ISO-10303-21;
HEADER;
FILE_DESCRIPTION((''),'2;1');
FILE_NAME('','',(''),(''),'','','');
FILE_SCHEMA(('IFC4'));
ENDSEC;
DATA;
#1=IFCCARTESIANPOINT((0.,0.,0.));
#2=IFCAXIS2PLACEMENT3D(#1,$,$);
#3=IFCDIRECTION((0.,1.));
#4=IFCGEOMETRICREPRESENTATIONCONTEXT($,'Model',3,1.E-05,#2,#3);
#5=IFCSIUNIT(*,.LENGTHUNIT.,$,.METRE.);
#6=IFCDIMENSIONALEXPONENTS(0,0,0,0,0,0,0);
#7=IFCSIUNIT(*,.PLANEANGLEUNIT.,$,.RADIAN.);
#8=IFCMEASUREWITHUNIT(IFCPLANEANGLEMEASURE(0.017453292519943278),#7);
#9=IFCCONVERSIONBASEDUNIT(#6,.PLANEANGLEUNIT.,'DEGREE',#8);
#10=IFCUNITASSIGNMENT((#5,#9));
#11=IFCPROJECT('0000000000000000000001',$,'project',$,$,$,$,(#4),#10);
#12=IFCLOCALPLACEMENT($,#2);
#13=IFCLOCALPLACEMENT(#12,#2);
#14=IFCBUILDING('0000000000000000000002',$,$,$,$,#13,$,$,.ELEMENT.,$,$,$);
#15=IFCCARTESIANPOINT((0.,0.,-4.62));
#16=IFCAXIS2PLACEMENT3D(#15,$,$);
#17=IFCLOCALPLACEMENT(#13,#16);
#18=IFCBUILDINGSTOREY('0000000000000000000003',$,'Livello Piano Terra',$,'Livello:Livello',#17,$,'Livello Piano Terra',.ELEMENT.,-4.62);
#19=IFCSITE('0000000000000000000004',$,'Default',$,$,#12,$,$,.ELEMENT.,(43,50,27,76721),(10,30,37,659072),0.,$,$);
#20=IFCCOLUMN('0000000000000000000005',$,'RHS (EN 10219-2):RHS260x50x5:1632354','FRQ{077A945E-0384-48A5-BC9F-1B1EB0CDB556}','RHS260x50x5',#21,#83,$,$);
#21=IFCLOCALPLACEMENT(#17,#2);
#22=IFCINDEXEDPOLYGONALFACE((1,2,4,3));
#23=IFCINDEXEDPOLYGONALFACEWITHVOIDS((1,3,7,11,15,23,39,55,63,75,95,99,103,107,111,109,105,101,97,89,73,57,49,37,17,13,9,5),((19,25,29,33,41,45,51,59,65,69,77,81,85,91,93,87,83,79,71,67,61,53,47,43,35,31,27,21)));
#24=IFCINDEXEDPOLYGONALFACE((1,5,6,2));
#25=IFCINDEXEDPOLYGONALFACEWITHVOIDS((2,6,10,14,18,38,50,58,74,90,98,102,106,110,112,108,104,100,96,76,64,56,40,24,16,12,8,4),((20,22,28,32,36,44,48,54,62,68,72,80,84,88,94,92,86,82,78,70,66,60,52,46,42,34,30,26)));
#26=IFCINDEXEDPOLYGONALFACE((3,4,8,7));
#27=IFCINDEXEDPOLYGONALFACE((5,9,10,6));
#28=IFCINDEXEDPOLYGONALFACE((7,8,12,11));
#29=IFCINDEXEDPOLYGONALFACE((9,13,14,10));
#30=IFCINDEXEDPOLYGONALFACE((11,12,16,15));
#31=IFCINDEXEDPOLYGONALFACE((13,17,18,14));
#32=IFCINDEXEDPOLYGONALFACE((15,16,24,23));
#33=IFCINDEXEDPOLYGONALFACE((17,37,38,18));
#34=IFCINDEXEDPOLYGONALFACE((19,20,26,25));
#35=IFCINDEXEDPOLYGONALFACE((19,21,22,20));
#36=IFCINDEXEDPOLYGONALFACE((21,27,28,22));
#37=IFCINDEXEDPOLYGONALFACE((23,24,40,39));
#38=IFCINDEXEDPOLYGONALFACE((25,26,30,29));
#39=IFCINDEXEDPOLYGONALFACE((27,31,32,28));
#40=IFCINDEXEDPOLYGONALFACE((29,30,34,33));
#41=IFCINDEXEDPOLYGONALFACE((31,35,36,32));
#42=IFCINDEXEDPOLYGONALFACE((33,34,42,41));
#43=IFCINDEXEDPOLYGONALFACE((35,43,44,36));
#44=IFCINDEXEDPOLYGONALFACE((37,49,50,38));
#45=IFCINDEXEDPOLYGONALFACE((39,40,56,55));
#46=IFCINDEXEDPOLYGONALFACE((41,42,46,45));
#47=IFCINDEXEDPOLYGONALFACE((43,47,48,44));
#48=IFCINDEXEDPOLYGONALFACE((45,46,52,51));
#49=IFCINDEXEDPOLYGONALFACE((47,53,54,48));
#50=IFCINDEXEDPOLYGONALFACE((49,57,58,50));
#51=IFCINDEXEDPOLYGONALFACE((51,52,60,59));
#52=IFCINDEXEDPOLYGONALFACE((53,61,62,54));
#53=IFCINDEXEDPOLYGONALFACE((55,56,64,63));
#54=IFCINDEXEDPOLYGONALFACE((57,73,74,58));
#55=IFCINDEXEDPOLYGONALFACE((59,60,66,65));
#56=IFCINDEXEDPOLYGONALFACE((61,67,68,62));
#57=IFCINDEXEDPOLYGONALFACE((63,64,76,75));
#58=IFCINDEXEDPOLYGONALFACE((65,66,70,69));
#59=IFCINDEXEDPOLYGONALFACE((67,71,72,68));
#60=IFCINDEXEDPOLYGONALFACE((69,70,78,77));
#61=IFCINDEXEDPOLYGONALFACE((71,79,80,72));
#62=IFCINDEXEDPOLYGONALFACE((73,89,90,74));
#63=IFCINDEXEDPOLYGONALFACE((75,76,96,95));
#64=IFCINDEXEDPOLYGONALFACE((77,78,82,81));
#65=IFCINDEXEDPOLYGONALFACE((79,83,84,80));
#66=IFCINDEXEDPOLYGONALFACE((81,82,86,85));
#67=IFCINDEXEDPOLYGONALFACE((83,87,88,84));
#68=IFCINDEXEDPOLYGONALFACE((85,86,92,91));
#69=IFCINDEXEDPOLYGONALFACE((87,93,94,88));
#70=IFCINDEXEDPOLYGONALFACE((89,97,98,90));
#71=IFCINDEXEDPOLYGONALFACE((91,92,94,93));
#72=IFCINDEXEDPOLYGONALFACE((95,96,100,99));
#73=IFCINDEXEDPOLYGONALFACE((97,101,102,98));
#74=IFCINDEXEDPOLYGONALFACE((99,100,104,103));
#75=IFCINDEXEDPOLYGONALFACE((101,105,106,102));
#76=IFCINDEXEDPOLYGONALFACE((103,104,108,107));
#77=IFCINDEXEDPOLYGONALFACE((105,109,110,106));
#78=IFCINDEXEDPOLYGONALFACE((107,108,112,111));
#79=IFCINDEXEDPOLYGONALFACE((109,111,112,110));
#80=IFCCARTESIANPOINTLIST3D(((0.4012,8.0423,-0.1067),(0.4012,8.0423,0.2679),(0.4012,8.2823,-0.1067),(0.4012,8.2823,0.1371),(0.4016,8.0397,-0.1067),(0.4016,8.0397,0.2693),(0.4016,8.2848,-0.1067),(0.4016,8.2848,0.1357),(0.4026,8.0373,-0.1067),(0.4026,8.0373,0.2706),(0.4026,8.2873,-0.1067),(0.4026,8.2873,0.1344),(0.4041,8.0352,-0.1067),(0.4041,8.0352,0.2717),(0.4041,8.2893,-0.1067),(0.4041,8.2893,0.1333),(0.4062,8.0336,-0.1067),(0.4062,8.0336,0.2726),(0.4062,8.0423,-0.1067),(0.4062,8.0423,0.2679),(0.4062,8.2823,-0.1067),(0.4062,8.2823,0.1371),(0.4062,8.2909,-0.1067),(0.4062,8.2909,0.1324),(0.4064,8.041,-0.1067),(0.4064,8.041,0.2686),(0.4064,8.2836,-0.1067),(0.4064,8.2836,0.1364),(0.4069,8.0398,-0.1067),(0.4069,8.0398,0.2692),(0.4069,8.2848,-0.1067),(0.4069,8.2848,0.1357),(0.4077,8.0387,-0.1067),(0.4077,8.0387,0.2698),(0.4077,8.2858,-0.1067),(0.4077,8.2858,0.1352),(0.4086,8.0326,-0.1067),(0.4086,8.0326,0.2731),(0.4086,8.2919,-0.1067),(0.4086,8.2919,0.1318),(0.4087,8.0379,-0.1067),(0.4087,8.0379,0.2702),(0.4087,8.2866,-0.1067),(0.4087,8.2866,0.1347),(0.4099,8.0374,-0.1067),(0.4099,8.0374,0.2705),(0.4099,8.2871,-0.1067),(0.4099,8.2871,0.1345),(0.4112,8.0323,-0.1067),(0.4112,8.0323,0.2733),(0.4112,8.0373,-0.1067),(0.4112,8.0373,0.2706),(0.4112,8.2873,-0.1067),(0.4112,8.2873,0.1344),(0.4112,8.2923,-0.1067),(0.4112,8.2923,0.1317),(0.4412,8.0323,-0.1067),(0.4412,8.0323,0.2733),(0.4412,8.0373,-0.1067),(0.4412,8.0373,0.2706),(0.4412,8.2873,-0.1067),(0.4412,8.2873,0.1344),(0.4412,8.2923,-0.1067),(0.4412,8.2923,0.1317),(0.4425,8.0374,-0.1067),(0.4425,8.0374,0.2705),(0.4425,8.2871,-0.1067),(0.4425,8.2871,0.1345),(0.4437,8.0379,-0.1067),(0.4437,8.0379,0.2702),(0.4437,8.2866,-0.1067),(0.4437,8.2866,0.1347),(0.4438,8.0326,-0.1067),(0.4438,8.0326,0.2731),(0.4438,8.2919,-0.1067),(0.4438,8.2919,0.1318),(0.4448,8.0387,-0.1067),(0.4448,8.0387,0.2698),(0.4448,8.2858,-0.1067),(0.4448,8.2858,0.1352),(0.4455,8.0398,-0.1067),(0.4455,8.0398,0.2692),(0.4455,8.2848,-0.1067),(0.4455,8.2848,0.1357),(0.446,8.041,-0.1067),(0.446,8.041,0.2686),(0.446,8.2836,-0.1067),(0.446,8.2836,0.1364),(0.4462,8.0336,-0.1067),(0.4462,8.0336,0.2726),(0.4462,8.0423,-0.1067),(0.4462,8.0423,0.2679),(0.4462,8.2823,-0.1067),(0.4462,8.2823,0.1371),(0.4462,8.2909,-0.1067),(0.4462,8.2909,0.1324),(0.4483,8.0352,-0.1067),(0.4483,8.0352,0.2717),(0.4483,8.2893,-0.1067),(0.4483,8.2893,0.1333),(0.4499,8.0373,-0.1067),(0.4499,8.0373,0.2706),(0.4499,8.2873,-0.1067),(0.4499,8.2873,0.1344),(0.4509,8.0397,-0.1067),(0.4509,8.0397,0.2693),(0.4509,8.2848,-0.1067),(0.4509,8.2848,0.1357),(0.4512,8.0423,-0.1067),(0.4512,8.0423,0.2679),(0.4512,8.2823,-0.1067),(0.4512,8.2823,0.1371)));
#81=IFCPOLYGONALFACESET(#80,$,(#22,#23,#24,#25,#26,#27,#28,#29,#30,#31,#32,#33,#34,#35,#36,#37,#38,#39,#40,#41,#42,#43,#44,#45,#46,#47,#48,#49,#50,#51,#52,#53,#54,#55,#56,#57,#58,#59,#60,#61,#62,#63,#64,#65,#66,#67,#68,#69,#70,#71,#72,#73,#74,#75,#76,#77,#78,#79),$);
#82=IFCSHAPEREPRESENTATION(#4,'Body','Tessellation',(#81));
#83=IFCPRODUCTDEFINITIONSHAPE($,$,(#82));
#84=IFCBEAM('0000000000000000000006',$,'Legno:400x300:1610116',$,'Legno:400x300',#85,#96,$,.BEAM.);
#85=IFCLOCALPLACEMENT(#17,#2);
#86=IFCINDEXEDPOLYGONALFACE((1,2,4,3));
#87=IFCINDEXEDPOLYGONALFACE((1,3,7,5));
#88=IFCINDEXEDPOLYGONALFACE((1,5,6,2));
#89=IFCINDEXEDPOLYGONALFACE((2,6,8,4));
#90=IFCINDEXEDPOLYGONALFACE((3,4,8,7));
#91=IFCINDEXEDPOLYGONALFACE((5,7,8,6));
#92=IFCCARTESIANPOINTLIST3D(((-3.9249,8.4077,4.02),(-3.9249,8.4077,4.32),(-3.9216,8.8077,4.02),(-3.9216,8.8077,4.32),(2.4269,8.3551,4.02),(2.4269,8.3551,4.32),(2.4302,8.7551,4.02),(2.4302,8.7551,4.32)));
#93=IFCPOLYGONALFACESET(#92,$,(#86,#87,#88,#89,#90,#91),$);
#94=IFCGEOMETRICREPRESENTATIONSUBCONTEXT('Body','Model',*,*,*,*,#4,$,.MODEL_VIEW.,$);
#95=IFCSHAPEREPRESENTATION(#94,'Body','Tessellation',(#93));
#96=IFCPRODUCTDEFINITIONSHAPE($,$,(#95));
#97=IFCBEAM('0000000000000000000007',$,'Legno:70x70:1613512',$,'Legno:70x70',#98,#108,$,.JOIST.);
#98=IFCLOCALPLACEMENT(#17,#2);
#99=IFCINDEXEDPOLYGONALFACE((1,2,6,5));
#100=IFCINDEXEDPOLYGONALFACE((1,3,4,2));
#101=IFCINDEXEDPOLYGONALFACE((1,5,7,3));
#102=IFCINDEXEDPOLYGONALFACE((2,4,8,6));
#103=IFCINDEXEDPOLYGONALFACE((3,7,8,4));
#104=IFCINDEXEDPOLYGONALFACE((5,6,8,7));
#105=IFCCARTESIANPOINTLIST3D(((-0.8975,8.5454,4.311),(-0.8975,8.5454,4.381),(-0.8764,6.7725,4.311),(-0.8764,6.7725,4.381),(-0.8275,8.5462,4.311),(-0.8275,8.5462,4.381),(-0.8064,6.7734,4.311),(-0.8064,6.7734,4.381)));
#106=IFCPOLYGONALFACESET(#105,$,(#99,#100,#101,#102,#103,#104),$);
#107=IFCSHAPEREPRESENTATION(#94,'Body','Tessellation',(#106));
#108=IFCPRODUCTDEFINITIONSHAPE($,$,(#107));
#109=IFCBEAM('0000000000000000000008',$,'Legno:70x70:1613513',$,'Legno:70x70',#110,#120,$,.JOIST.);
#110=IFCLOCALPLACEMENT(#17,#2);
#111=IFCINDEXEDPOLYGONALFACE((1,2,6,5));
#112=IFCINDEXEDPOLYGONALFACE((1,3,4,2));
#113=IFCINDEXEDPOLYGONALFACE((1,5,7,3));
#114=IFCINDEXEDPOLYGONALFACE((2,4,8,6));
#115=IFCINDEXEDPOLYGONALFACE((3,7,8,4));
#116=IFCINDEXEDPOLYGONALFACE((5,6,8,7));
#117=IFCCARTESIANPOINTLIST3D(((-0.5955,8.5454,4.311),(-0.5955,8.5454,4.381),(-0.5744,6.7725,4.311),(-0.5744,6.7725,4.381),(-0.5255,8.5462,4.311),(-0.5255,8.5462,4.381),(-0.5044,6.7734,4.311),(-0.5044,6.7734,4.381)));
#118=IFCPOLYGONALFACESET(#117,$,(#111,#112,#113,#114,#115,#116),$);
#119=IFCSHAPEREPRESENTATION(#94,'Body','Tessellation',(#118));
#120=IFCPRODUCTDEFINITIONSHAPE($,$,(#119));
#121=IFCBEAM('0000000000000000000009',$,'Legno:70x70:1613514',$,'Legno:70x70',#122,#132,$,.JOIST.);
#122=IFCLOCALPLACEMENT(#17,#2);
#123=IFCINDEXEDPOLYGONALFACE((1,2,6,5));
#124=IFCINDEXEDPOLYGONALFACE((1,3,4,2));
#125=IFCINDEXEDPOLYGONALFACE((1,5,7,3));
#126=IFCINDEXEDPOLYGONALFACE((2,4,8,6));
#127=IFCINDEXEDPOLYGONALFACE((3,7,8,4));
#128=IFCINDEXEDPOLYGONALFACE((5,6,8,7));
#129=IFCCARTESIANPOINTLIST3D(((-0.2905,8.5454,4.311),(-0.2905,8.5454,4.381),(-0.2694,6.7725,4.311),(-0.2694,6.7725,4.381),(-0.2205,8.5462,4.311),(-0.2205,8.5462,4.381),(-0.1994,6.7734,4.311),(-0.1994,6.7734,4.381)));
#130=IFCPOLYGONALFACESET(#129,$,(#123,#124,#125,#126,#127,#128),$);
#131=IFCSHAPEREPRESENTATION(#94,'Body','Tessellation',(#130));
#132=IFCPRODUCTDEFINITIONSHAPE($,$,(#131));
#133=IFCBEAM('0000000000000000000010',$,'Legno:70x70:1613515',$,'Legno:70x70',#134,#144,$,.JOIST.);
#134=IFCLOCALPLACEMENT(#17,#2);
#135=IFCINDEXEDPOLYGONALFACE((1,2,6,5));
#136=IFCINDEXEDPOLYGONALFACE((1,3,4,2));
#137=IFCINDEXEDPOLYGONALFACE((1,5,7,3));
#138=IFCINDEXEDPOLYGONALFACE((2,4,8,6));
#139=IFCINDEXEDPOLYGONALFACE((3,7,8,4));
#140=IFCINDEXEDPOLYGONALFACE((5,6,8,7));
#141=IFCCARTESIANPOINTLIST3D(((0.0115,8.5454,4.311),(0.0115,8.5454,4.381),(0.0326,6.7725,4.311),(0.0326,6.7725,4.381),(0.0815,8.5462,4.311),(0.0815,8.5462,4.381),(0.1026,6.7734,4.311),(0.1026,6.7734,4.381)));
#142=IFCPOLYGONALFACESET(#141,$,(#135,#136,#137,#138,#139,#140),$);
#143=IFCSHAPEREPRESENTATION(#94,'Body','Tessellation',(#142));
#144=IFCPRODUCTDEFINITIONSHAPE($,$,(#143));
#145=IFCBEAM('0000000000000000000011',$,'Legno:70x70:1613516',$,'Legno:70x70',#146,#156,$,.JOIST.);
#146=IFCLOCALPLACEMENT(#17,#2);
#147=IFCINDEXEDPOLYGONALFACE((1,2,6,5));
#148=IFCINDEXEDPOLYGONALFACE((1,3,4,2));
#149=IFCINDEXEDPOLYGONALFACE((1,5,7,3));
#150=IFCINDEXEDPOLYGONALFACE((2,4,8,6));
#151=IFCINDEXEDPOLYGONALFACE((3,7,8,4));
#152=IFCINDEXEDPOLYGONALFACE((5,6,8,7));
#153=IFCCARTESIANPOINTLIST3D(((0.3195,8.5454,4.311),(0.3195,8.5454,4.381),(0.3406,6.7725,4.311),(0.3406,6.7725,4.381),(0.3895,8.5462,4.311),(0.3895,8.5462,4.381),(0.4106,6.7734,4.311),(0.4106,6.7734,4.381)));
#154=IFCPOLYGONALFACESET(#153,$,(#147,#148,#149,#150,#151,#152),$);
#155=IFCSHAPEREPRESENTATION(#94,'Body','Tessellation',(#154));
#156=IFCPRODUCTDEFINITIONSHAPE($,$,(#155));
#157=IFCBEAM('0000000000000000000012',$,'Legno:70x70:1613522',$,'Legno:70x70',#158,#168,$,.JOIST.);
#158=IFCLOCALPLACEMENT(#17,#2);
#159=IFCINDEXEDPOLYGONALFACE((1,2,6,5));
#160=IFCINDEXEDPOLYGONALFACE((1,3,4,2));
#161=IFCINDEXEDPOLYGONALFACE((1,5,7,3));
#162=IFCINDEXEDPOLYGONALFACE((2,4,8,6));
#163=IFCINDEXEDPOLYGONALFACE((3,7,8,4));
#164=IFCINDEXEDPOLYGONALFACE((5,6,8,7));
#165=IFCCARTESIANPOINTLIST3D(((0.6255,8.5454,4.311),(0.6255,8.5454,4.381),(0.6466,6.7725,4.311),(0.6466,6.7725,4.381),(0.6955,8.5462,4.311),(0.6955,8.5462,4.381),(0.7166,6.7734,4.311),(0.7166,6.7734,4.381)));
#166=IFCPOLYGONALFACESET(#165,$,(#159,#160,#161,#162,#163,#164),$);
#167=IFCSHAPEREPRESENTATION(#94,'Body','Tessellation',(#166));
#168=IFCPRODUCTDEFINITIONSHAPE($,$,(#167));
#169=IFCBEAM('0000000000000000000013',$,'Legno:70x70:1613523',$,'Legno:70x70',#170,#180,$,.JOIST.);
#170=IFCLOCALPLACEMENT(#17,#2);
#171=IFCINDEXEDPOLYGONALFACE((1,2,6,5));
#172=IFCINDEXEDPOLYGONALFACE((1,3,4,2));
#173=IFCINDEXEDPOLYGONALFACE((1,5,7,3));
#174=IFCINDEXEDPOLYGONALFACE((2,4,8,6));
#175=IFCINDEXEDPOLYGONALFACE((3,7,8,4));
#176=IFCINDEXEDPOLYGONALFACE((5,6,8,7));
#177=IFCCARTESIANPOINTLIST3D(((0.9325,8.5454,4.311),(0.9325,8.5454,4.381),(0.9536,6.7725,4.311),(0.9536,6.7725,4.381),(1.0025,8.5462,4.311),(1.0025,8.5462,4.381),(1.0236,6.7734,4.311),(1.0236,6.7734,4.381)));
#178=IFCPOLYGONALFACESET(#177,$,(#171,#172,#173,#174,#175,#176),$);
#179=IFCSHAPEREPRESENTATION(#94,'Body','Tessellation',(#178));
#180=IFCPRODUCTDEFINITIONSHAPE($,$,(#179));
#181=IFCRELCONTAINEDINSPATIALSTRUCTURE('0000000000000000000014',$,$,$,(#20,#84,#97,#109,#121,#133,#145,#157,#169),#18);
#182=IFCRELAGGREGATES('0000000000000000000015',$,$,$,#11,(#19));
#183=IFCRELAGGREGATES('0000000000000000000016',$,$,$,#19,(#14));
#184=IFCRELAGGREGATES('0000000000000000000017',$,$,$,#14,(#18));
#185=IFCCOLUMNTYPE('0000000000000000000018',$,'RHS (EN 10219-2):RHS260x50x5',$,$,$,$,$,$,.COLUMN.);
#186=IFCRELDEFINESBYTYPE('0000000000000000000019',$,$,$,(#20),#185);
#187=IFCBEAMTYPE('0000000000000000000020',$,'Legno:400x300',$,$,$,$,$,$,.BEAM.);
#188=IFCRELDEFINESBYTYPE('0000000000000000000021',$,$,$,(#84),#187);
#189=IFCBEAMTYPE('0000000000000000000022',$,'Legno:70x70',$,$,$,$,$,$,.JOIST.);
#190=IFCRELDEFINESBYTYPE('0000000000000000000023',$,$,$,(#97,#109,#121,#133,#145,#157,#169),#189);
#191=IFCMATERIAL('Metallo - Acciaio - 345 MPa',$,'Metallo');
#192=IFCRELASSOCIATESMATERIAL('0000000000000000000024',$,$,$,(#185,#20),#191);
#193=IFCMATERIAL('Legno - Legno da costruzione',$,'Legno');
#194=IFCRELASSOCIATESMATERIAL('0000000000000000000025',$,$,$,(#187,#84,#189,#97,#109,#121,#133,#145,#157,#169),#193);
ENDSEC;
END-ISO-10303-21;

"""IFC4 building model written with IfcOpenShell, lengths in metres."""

from ifc_helpers import new_model, entity, si_unit, converted_unit, direction, frame, origin, origin_2d, place, context, subcontext, project, spatial, indexed_curve, hollow_rectangle, outline, extrude, clip, halfspace, source, transform, mapped, material, type_object, type_shapes, element, save


model = new_model("IFC4")

# Units and contexts
model_context = context("Model", 3, precision=1e-05, world=origin(), true_north=direction((0.0, 1.0)))
body_context = subcontext(model_context, "Body", "Model", "MODEL_VIEW")
ifc_project = project(units=[si_unit("LENGTHUNIT", "METRE"), converted_unit("PLANEANGLEUNIT", "DEGREE", entity("IfcPlaneAngleMeasure", 0.017453292519943278), si_unit("PLANEANGLEUNIT", "RADIAN"), dimensions=[0, 0, 0, 0, 0, 0, 0])], contexts=[model_context])

# Site, building, storey
site_placement = place(None, origin())
site = spatial("IfcSite", under=ifc_project, at=site_placement, Name="Default", CompositionType="ELEMENT", RefLatitude=(43, 50, 27, 76721), RefLongitude=(10, 30, 37, 659072), RefElevation=0.0)
building_placement = place(site_placement, origin())
building = spatial("IfcBuilding", under=site, at=building_placement, CompositionType="ELEMENT")
storey_placement = place(building_placement, frame((0.0, 0.0, -4.62)))
storey = spatial("IfcBuildingStorey", under=building, at=storey_placement, Name="Livello Piano Terra", ObjectType="Livello:Livello", LongName="Livello Piano Terra", CompositionType="ELEMENT", Elevation=-4.62)

# Column
ifc_material_1 = material(Name="Metallo - Acciaio - 345 MPa", Category="Metallo")
column_type = type_object("IfcColumnType", Name="RHS (EN 10219-2):RHS260x50x5", PredefinedType="COLUMN", material=ifc_material_1)
column_1_placement = place(storey_placement, frame((0.4262, 8.1623, -0.1067), z_axis=(0.0, 0.0, -1.0), x_axis=(1.0, 0.0, 0.0)))
element("IfcColumn", 1, at=column_1_placement, inside=storey, type_object=column_type, material=ifc_material_1, Name="RHS (EN 10219-2):RHS260x50x5:1632354", Description="FRQ{077A945E-0384-48A5-BC9F-1B1EB0CDB556}", ObjectType="RHS260x50x5", context=model_context, shape_type="Clipping", body=[
    clip(extrude(hollow_rectangle(XDim=0.05, YDim=0.26, WallThickness=0.005, InnerFilletRadius=0.005, OuterFilletRadius=0.01, at=origin_2d()), origin(), (0.0, 0.0, -1.0), 0.8268), halfspace(frame((-0.4044, 8.1509, -4.7497), z_axis=(0.0, 0.478399, 0.878142), x_axis=(1.0, 0.0, 0.0)), True)),
])

# Beams
ifc_material_2 = material(Name="Legno - Legno da costruzione", Category="Legno")
beam_type_1 = type_object("IfcBeamType", Name="Legno:400x300", PredefinedType="BEAM", material=ifc_material_2)
shared_shape_1 = source(origin(), body_context, "Body", "SweptSolid", [
    extrude(outline(indexed_curve([(-3.176, -0.2), (3.176, -0.2), (3.176, 0.2), (-3.176, 0.2), (-3.176, -0.2)], self_intersect=False)), frame((0.0, 0.0, -0.15), z_axis=(0.0, 0.0, 1.0), x_axis=(-1.0, 0.0, 0.0)), (0.0, 0.0, 1.0), 0.3),
])
type_shapes(beam_type_1, [shared_shape_1])
beam_1_placement = place(storey_placement, frame((-0.7474, 8.5814, 4.17), z_axis=(0.0, 0.0, 1.0), x_axis=(0.999966, -0.008283, 0.0)))
element("IfcBeam", 2, at=beam_1_placement, inside=storey, type_object=beam_type_1, material=ifc_material_2, Name="Legno:400x300:1610116", ObjectType="Legno:400x300", PredefinedType="BEAM", context=body_context, shape_type="MappedRepresentation", body=[
    mapped(shared_shape_1, transform((0.0, 0.0, 0.0), scale=1.0)),
])
beam_type_2 = type_object("IfcBeamType", Name="Legno:70x70", PredefinedType="JOIST", material=ifc_material_2)
shared_shape_2 = source(origin(), body_context, "Body", "SweptSolid", [
    extrude(outline(indexed_curve([(-0.8865, -0.035), (0.8865, -0.035), (0.8865, 0.035), (-0.8865, 0.035), (-0.8865, -0.035)], self_intersect=False)), frame((0.0, 0.0, -0.035), z_axis=(0.0, 0.0, 1.0), x_axis=(-1.0, 0.0, 0.0)), (0.0, 0.0, 1.0), 0.07),
])
type_shapes(beam_type_2, [shared_shape_2])
for number, where, z_axis, x_axis, name in (
    (3, (-0.8519, 7.6594, 4.346), (0.0, 0.0, 1.0), (0.011914, -0.999929, 0.0), "Legno:70x70:1613512"),
    (4, (-0.5499, 7.6594, 4.346), (0.0, 0.0, 1.0), (0.011914, -0.999929, 0.0), "Legno:70x70:1613513"),
    (5, (-0.2449, 7.6594, 4.346), (0.0, 0.0, 1.0), (0.011914, -0.999929, 0.0), "Legno:70x70:1613514"),
    (6, (0.0571, 7.6594, 4.346), (0.0, 0.0, 1.0), (0.011914, -0.999929, 0.0), "Legno:70x70:1613515"),
    (7, (0.3651, 7.6594, 4.346), (0.0, 0.0, 1.0), (0.011914, -0.999929, 0.0), "Legno:70x70:1613516"),
    (8, (0.6711, 7.6594, 4.346), (0.0, 0.0, 1.0), (0.011914, -0.999929, 0.0), "Legno:70x70:1613522"),
    (9, (0.9781, 7.6594, 4.346), (0.0, 0.0, 1.0), (0.011914, -0.999929, 0.0), "Legno:70x70:1613523"),
):
    element("IfcBeam", number, at=place(storey_placement, frame(where, z_axis=z_axis, x_axis=x_axis)), inside=storey, type_object=beam_type_2, material=ifc_material_2, Name=name, ObjectType="Legno:70x70", PredefinedType="JOIST", context=body_context, shape_type="MappedRepresentation", body=[
        mapped(shared_shape_2, transform((0.0, 0.0, 0.0), scale=1.0)),
    ])

save(model, "model.ifc")
